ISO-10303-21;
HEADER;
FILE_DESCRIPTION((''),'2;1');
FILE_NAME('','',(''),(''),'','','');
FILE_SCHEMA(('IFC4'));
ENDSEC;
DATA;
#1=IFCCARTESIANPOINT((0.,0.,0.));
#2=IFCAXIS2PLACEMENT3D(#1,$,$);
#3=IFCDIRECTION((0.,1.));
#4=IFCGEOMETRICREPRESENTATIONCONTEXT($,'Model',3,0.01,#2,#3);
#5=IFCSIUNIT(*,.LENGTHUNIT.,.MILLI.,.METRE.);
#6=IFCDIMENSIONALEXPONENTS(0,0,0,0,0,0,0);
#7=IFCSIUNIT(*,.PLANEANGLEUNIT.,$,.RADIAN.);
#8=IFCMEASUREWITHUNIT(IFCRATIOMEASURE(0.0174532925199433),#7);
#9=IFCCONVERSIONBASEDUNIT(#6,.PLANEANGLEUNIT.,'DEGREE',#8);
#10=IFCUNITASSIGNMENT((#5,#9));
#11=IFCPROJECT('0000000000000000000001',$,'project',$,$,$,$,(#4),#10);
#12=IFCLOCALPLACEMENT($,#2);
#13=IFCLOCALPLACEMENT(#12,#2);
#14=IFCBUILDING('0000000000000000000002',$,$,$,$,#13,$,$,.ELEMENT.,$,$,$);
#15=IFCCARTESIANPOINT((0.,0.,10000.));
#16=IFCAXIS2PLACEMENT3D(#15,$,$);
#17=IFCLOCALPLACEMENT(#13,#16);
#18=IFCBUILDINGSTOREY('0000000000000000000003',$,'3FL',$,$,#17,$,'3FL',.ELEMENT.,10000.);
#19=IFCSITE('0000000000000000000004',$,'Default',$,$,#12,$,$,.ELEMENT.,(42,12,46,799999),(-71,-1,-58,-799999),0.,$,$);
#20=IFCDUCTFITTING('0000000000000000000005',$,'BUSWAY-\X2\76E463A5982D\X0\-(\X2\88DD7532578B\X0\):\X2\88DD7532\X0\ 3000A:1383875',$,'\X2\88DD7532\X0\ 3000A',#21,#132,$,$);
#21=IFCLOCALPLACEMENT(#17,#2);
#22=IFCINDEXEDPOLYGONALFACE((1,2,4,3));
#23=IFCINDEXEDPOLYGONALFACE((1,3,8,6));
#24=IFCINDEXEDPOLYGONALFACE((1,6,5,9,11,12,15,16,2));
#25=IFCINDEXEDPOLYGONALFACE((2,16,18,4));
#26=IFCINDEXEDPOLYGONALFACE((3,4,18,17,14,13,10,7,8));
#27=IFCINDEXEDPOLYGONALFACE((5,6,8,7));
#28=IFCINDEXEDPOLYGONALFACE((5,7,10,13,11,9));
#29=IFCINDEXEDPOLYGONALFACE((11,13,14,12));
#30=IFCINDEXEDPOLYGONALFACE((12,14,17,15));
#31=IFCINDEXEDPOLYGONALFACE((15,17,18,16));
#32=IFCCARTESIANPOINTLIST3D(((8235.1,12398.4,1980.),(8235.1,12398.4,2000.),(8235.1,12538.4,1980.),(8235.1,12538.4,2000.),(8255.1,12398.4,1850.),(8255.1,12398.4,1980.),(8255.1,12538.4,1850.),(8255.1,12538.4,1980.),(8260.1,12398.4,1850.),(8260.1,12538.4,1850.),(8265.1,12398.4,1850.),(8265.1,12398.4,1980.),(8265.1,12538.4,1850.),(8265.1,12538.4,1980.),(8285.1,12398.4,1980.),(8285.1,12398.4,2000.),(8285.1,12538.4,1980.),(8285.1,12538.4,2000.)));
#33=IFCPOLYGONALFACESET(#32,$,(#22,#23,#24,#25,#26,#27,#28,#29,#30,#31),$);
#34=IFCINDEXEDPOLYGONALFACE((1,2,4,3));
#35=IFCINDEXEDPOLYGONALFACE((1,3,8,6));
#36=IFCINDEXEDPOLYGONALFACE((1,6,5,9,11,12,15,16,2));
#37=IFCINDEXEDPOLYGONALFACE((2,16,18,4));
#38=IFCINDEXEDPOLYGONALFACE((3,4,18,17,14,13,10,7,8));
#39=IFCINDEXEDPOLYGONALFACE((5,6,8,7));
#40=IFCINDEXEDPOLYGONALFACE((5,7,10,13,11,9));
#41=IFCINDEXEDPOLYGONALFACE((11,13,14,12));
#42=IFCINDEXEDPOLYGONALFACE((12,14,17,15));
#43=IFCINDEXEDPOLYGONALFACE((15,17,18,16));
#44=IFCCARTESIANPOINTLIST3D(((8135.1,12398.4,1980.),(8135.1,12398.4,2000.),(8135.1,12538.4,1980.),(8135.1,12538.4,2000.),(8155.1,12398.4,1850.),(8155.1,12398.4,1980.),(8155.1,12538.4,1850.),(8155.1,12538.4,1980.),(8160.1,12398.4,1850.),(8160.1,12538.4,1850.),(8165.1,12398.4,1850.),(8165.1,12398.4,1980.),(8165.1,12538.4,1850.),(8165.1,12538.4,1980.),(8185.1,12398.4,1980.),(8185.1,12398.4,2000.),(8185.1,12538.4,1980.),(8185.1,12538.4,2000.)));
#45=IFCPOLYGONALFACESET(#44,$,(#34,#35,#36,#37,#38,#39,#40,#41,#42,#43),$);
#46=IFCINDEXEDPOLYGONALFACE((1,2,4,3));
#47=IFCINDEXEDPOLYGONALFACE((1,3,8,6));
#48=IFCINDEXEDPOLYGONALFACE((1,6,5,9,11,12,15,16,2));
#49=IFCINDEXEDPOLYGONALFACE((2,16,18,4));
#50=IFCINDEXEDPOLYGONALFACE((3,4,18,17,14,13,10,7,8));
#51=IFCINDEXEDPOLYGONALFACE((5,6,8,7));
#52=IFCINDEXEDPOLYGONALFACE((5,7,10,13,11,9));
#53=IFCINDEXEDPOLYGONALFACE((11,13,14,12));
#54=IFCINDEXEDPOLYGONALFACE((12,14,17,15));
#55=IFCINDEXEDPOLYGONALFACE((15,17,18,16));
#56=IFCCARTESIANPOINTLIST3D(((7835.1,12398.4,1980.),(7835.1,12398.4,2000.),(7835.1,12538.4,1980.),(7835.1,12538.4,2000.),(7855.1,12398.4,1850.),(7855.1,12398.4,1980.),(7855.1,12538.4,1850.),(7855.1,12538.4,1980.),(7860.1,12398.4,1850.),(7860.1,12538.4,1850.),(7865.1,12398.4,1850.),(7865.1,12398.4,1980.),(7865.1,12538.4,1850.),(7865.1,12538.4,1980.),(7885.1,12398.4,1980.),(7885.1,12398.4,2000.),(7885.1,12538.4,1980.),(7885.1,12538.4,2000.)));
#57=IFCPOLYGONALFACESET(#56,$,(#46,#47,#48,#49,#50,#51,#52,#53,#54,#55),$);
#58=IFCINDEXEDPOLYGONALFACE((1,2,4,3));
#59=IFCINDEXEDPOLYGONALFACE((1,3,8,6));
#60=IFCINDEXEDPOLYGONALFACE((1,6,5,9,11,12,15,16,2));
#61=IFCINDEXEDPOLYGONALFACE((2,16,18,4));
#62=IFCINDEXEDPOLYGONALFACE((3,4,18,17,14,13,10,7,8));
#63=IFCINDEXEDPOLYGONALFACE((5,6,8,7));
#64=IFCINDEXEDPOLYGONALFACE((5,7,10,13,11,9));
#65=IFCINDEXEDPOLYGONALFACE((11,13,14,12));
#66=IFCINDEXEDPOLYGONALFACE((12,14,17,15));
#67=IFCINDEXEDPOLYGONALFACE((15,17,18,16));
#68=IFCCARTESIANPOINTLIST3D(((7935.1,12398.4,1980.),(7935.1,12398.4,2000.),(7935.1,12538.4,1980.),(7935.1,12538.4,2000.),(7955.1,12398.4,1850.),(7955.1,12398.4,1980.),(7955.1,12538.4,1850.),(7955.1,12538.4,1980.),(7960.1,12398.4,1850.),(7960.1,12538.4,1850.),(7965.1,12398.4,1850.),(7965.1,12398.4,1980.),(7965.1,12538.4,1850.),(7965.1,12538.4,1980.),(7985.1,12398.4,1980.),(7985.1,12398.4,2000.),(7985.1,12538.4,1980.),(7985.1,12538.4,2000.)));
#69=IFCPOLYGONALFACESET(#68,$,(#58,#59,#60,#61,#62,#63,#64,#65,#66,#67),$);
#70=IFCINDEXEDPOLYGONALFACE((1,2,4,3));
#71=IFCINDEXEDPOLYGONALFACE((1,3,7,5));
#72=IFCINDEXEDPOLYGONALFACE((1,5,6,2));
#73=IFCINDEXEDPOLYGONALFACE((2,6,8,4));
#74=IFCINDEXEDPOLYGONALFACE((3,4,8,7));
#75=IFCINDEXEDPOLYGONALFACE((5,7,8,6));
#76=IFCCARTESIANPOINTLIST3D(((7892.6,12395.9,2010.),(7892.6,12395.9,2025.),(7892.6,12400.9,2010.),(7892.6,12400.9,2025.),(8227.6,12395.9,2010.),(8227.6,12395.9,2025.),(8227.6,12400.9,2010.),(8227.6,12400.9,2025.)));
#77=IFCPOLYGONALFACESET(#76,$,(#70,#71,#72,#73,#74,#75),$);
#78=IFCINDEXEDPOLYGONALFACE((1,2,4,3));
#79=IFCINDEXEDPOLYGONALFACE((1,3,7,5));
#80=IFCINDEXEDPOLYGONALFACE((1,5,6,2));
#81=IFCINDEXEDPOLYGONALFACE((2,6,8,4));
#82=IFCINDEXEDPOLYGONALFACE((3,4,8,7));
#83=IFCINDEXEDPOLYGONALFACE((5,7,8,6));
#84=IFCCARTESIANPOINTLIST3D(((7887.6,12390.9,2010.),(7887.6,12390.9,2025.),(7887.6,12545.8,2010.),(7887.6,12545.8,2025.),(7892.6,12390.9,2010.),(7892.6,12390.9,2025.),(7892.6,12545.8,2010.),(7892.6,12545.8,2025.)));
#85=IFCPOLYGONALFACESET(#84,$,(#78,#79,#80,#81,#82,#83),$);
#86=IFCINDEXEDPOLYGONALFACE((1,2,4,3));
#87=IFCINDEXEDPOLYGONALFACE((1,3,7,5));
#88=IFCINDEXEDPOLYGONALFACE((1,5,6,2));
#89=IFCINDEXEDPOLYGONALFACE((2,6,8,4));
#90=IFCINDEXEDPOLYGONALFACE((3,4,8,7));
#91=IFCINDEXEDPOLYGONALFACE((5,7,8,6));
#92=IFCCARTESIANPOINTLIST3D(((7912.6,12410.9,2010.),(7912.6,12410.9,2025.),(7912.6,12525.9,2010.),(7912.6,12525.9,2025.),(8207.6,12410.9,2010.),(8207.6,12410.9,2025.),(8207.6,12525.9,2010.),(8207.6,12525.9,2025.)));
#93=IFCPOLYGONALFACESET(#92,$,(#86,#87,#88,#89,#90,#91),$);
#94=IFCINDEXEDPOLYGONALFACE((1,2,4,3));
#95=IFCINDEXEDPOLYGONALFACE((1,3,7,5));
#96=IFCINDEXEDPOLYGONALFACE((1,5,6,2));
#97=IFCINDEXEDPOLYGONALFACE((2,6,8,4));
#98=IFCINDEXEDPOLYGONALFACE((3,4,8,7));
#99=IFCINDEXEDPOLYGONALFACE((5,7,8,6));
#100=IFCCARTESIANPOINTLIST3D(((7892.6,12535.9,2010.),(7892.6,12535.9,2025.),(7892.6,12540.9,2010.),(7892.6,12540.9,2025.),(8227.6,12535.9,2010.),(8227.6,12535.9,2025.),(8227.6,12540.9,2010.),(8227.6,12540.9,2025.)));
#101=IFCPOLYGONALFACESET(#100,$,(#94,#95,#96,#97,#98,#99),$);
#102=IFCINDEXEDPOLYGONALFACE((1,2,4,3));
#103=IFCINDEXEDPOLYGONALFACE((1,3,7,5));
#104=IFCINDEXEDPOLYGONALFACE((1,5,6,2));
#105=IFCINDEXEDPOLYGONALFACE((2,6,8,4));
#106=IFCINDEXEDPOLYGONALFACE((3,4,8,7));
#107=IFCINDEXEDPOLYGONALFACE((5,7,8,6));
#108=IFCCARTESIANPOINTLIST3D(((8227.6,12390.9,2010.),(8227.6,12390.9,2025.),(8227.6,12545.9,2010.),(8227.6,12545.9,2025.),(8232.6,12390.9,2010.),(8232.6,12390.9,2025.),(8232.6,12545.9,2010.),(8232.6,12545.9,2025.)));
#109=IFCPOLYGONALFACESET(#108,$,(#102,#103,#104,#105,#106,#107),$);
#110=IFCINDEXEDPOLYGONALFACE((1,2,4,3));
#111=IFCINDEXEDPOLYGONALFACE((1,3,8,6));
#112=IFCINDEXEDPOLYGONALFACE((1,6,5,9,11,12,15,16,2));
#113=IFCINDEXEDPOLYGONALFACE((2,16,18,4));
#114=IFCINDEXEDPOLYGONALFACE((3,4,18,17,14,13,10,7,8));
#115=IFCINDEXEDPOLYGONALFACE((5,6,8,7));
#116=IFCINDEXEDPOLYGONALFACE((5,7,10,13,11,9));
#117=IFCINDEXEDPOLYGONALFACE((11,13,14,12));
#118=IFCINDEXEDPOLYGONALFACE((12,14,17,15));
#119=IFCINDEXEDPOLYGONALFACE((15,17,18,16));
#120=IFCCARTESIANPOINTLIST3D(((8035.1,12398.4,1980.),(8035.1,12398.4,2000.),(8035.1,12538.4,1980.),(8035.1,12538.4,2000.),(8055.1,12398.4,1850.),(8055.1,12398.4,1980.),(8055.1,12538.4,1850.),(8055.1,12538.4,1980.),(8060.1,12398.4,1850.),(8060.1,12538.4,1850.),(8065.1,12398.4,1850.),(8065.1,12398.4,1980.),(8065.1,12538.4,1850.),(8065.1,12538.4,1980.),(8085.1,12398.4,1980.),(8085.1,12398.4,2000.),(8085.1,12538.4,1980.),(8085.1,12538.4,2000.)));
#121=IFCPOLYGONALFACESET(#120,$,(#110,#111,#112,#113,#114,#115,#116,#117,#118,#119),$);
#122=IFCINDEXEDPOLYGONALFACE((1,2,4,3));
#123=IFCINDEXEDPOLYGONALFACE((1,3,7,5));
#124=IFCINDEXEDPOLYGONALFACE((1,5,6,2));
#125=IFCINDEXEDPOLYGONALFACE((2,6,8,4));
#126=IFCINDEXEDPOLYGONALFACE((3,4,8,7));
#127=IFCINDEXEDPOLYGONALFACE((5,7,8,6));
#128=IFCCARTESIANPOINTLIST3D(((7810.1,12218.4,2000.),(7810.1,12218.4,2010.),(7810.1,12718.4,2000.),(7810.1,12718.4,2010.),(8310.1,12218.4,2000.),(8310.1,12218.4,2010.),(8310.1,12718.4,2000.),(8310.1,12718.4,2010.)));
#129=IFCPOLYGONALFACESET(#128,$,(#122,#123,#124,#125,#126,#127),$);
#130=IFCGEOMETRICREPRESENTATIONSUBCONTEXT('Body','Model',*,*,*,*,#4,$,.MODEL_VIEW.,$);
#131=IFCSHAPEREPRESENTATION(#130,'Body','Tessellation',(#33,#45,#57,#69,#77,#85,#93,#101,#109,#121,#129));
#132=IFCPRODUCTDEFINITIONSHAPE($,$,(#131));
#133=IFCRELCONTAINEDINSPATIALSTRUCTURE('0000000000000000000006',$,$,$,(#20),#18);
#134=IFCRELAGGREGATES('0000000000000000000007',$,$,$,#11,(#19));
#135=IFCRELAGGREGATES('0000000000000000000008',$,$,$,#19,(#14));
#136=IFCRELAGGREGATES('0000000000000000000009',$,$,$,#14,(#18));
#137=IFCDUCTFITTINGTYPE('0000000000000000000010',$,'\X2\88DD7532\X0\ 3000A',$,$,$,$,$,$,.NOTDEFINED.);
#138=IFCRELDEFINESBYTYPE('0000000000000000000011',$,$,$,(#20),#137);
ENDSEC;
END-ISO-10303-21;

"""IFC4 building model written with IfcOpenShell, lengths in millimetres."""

from ifc_helpers import new_model, entity, si_unit, converted_unit, direction, frame, frame_2d, origin, origin_2d_with_axis, place, context, subcontext, project, spatial, polyline, rectangle, outline, extrude, source, transform, mapped, type_object, type_shapes, element, save


model = new_model("IFC4")

# Units and contexts
model_context = context("Model", 3, precision=0.01, world=origin(), true_north=direction((0.0, 1.0)))
body_context = subcontext(model_context, "Body", "Model", "MODEL_VIEW")
ifc_project = project(units=[si_unit("LENGTHUNIT", "METRE", prefix="MILLI"), converted_unit("PLANEANGLEUNIT", "DEGREE", entity("IfcRatioMeasure", 0.0174532925199433), si_unit("PLANEANGLEUNIT", "RADIAN"), dimensions=[0, 0, 0, 0, 0, 0, 0])], contexts=[model_context])

# Site, building, storey
site_placement = place(None, origin())
site = spatial("IfcSite", under=ifc_project, at=site_placement, Name="Default", CompositionType="ELEMENT", RefLatitude=(42, 12, 46, 799999), RefLongitude=(-71, -1, -58, -799999), RefElevation=0.0)
building_placement = place(site_placement, origin())
building = spatial("IfcBuilding", under=site, at=building_placement, CompositionType="ELEMENT")
storey_placement = place(building_placement, frame((0.0, 0.0, 10000.0)))
storey = spatial("IfcBuildingStorey", under=building, at=storey_placement, Name="3FL", LongName="3FL", CompositionType="ELEMENT", Elevation=10000.0)

# Duct fitting
duct_fitting_type_1 = type_object("IfcDuctFittingType", Name="裝甲 3000A", PredefinedType="NOTDEFINED")
shared_shape_1 = source(origin(), body_context, "Body", "SweptSolid", [
    extrude(outline(polyline([(-25.0, -58.9), (25.0, -58.9), (25.0, -38.9), (5.0, -38.9), (5.0, 91.1), (0.0, 91.1), (-5.0, 91.1), (-5.0, -38.9), (-25.0, -38.9), (-25.0, -58.9)])), frame((-200.0, -70.0, -58.9), z_axis=(0.0, 1.0, 0.0), x_axis=(1.0, 0.0, 0.0)), (0.0, 0.0, 1.0), 140.0),
    extrude(outline(polyline([(-25.0, -58.9), (25.0, -58.9), (25.0, -38.9), (5.0, -38.9), (5.0, 91.1), (0.0, 91.1), (-5.0, 91.1), (-5.0, -38.9), (-25.0, -38.9), (-25.0, -58.9)])), frame((-100.0, -70.0, -58.9), z_axis=(0.0, 1.0, 0.0), x_axis=(1.0, 0.0, 0.0)), (0.0, 0.0, 1.0), 140.0),
    extrude(outline(polyline([(-58.9, -25.0), (-38.9, -25.0), (-38.9, -5.0), (91.1, -5.0), (91.1, 0.0), (91.1, 5.0), (-38.9, 5.0), (-38.9, 25.0), (-58.9, 25.0), (-58.9, -25.0)])), frame((200.0, -70.0, -58.9), z_axis=(0.0, 1.0, 0.0), x_axis=(0.0, 0.0, -1.0)), (0.0, 0.0, 1.0), 140.0),
    extrude(outline(polyline([(-58.9, -25.0), (-38.9, -25.0), (-38.9, -5.0), (91.1, -5.0), (91.1, 0.0), (91.1, 5.0), (-38.9, 5.0), (-38.9, 25.0), (-58.9, 25.0), (-58.9, -25.0)])), frame((100.0, -70.0, -58.9), z_axis=(0.0, 1.0, 0.0), x_axis=(0.0, 0.0, -1.0)), (0.0, 0.0, 1.0), 140.0),
    extrude(rectangle(XDim=5.0, YDim=335.0, at=origin_2d_with_axis()), frame((0.0, 70.0, 10.0), z_axis=(0.0, 0.0, 1.0), x_axis=(0.0, 1.0, 0.0)), (0.0, 0.0, 1.0), 15.0),
    extrude(rectangle(XDim=154.9, YDim=5.0, at=frame_2d((0.0, 0.0), x_axis=(1.0, 0.0))), frame((170.0, 0.1, 10.0), z_axis=(0.0, 0.0, 1.0), x_axis=(0.0, 1.0, 0.0)), (0.0, 0.0, 1.0), 15.0),
    extrude(rectangle(XDim=115.0, YDim=295.0, at=origin_2d_with_axis()), frame((0.0, 0.0, 10.0), z_axis=(0.0, 0.0, 1.0), x_axis=(0.0, 1.0, 0.0)), (0.0, 0.0, 1.0), 15.0),
    extrude(rectangle(XDim=5.0, YDim=335.0, at=origin_2d_with_axis()), frame((0.0, -70.0, 10.0), z_axis=(0.0, 0.0, 1.0), x_axis=(0.0, 1.0, 0.0)), (0.0, 0.0, 1.0), 15.0),
    extrude(rectangle(XDim=155.0, YDim=5.0, at=origin_2d_with_axis()), frame((-170.0, 0.0, 10.0), z_axis=(0.0, 0.0, 1.0), x_axis=(0.0, 1.0, 0.0)), (0.0, 0.0, 1.0), 15.0),
    extrude(outline(polyline([(-58.9, -25.0), (-38.9, -25.0), (-38.9, -5.0), (91.1, -5.0), (91.1, 0.0), (91.1, 5.0), (-38.9, 5.0), (-38.9, 25.0), (-58.9, 25.0), (-58.9, -25.0)])), frame((0.0, -70.0, -58.9), z_axis=(0.0, 1.0, 0.0), x_axis=(0.0, 0.0, -1.0)), (0.0, 0.0, 1.0), 140.0),
    extrude(rectangle(XDim=500.0, YDim=500.0, at=origin_2d_with_axis()), frame((0.0, 0.0, 0.0), z_axis=(0.0, 0.0, 1.0), x_axis=(-1.0, 0.0, 0.0)), (0.0, 0.0, 1.0), 10.0),
])
type_shapes(duct_fitting_type_1, [shared_shape_1])
duct_fitting_1_placement = place(storey_placement, frame((8060.1, 12468.4, 2000.0), z_axis=(0.0, 0.0, 1.0), x_axis=(-1.0, 0.0, 0.0)))
element("IfcDuctFitting", 1, at=duct_fitting_1_placement, inside=storey, type_object=duct_fitting_type_1, Name="BUSWAY-盤接頭-(裝甲型):裝甲 3000A:1383875", ObjectType="裝甲 3000A", context=body_context, shape_type="MappedRepresentation", body=[
    mapped(shared_shape_1, transform((0.0, 0.0, 0.0), scale=1.0)),
])

save(model, "model.ifc")
